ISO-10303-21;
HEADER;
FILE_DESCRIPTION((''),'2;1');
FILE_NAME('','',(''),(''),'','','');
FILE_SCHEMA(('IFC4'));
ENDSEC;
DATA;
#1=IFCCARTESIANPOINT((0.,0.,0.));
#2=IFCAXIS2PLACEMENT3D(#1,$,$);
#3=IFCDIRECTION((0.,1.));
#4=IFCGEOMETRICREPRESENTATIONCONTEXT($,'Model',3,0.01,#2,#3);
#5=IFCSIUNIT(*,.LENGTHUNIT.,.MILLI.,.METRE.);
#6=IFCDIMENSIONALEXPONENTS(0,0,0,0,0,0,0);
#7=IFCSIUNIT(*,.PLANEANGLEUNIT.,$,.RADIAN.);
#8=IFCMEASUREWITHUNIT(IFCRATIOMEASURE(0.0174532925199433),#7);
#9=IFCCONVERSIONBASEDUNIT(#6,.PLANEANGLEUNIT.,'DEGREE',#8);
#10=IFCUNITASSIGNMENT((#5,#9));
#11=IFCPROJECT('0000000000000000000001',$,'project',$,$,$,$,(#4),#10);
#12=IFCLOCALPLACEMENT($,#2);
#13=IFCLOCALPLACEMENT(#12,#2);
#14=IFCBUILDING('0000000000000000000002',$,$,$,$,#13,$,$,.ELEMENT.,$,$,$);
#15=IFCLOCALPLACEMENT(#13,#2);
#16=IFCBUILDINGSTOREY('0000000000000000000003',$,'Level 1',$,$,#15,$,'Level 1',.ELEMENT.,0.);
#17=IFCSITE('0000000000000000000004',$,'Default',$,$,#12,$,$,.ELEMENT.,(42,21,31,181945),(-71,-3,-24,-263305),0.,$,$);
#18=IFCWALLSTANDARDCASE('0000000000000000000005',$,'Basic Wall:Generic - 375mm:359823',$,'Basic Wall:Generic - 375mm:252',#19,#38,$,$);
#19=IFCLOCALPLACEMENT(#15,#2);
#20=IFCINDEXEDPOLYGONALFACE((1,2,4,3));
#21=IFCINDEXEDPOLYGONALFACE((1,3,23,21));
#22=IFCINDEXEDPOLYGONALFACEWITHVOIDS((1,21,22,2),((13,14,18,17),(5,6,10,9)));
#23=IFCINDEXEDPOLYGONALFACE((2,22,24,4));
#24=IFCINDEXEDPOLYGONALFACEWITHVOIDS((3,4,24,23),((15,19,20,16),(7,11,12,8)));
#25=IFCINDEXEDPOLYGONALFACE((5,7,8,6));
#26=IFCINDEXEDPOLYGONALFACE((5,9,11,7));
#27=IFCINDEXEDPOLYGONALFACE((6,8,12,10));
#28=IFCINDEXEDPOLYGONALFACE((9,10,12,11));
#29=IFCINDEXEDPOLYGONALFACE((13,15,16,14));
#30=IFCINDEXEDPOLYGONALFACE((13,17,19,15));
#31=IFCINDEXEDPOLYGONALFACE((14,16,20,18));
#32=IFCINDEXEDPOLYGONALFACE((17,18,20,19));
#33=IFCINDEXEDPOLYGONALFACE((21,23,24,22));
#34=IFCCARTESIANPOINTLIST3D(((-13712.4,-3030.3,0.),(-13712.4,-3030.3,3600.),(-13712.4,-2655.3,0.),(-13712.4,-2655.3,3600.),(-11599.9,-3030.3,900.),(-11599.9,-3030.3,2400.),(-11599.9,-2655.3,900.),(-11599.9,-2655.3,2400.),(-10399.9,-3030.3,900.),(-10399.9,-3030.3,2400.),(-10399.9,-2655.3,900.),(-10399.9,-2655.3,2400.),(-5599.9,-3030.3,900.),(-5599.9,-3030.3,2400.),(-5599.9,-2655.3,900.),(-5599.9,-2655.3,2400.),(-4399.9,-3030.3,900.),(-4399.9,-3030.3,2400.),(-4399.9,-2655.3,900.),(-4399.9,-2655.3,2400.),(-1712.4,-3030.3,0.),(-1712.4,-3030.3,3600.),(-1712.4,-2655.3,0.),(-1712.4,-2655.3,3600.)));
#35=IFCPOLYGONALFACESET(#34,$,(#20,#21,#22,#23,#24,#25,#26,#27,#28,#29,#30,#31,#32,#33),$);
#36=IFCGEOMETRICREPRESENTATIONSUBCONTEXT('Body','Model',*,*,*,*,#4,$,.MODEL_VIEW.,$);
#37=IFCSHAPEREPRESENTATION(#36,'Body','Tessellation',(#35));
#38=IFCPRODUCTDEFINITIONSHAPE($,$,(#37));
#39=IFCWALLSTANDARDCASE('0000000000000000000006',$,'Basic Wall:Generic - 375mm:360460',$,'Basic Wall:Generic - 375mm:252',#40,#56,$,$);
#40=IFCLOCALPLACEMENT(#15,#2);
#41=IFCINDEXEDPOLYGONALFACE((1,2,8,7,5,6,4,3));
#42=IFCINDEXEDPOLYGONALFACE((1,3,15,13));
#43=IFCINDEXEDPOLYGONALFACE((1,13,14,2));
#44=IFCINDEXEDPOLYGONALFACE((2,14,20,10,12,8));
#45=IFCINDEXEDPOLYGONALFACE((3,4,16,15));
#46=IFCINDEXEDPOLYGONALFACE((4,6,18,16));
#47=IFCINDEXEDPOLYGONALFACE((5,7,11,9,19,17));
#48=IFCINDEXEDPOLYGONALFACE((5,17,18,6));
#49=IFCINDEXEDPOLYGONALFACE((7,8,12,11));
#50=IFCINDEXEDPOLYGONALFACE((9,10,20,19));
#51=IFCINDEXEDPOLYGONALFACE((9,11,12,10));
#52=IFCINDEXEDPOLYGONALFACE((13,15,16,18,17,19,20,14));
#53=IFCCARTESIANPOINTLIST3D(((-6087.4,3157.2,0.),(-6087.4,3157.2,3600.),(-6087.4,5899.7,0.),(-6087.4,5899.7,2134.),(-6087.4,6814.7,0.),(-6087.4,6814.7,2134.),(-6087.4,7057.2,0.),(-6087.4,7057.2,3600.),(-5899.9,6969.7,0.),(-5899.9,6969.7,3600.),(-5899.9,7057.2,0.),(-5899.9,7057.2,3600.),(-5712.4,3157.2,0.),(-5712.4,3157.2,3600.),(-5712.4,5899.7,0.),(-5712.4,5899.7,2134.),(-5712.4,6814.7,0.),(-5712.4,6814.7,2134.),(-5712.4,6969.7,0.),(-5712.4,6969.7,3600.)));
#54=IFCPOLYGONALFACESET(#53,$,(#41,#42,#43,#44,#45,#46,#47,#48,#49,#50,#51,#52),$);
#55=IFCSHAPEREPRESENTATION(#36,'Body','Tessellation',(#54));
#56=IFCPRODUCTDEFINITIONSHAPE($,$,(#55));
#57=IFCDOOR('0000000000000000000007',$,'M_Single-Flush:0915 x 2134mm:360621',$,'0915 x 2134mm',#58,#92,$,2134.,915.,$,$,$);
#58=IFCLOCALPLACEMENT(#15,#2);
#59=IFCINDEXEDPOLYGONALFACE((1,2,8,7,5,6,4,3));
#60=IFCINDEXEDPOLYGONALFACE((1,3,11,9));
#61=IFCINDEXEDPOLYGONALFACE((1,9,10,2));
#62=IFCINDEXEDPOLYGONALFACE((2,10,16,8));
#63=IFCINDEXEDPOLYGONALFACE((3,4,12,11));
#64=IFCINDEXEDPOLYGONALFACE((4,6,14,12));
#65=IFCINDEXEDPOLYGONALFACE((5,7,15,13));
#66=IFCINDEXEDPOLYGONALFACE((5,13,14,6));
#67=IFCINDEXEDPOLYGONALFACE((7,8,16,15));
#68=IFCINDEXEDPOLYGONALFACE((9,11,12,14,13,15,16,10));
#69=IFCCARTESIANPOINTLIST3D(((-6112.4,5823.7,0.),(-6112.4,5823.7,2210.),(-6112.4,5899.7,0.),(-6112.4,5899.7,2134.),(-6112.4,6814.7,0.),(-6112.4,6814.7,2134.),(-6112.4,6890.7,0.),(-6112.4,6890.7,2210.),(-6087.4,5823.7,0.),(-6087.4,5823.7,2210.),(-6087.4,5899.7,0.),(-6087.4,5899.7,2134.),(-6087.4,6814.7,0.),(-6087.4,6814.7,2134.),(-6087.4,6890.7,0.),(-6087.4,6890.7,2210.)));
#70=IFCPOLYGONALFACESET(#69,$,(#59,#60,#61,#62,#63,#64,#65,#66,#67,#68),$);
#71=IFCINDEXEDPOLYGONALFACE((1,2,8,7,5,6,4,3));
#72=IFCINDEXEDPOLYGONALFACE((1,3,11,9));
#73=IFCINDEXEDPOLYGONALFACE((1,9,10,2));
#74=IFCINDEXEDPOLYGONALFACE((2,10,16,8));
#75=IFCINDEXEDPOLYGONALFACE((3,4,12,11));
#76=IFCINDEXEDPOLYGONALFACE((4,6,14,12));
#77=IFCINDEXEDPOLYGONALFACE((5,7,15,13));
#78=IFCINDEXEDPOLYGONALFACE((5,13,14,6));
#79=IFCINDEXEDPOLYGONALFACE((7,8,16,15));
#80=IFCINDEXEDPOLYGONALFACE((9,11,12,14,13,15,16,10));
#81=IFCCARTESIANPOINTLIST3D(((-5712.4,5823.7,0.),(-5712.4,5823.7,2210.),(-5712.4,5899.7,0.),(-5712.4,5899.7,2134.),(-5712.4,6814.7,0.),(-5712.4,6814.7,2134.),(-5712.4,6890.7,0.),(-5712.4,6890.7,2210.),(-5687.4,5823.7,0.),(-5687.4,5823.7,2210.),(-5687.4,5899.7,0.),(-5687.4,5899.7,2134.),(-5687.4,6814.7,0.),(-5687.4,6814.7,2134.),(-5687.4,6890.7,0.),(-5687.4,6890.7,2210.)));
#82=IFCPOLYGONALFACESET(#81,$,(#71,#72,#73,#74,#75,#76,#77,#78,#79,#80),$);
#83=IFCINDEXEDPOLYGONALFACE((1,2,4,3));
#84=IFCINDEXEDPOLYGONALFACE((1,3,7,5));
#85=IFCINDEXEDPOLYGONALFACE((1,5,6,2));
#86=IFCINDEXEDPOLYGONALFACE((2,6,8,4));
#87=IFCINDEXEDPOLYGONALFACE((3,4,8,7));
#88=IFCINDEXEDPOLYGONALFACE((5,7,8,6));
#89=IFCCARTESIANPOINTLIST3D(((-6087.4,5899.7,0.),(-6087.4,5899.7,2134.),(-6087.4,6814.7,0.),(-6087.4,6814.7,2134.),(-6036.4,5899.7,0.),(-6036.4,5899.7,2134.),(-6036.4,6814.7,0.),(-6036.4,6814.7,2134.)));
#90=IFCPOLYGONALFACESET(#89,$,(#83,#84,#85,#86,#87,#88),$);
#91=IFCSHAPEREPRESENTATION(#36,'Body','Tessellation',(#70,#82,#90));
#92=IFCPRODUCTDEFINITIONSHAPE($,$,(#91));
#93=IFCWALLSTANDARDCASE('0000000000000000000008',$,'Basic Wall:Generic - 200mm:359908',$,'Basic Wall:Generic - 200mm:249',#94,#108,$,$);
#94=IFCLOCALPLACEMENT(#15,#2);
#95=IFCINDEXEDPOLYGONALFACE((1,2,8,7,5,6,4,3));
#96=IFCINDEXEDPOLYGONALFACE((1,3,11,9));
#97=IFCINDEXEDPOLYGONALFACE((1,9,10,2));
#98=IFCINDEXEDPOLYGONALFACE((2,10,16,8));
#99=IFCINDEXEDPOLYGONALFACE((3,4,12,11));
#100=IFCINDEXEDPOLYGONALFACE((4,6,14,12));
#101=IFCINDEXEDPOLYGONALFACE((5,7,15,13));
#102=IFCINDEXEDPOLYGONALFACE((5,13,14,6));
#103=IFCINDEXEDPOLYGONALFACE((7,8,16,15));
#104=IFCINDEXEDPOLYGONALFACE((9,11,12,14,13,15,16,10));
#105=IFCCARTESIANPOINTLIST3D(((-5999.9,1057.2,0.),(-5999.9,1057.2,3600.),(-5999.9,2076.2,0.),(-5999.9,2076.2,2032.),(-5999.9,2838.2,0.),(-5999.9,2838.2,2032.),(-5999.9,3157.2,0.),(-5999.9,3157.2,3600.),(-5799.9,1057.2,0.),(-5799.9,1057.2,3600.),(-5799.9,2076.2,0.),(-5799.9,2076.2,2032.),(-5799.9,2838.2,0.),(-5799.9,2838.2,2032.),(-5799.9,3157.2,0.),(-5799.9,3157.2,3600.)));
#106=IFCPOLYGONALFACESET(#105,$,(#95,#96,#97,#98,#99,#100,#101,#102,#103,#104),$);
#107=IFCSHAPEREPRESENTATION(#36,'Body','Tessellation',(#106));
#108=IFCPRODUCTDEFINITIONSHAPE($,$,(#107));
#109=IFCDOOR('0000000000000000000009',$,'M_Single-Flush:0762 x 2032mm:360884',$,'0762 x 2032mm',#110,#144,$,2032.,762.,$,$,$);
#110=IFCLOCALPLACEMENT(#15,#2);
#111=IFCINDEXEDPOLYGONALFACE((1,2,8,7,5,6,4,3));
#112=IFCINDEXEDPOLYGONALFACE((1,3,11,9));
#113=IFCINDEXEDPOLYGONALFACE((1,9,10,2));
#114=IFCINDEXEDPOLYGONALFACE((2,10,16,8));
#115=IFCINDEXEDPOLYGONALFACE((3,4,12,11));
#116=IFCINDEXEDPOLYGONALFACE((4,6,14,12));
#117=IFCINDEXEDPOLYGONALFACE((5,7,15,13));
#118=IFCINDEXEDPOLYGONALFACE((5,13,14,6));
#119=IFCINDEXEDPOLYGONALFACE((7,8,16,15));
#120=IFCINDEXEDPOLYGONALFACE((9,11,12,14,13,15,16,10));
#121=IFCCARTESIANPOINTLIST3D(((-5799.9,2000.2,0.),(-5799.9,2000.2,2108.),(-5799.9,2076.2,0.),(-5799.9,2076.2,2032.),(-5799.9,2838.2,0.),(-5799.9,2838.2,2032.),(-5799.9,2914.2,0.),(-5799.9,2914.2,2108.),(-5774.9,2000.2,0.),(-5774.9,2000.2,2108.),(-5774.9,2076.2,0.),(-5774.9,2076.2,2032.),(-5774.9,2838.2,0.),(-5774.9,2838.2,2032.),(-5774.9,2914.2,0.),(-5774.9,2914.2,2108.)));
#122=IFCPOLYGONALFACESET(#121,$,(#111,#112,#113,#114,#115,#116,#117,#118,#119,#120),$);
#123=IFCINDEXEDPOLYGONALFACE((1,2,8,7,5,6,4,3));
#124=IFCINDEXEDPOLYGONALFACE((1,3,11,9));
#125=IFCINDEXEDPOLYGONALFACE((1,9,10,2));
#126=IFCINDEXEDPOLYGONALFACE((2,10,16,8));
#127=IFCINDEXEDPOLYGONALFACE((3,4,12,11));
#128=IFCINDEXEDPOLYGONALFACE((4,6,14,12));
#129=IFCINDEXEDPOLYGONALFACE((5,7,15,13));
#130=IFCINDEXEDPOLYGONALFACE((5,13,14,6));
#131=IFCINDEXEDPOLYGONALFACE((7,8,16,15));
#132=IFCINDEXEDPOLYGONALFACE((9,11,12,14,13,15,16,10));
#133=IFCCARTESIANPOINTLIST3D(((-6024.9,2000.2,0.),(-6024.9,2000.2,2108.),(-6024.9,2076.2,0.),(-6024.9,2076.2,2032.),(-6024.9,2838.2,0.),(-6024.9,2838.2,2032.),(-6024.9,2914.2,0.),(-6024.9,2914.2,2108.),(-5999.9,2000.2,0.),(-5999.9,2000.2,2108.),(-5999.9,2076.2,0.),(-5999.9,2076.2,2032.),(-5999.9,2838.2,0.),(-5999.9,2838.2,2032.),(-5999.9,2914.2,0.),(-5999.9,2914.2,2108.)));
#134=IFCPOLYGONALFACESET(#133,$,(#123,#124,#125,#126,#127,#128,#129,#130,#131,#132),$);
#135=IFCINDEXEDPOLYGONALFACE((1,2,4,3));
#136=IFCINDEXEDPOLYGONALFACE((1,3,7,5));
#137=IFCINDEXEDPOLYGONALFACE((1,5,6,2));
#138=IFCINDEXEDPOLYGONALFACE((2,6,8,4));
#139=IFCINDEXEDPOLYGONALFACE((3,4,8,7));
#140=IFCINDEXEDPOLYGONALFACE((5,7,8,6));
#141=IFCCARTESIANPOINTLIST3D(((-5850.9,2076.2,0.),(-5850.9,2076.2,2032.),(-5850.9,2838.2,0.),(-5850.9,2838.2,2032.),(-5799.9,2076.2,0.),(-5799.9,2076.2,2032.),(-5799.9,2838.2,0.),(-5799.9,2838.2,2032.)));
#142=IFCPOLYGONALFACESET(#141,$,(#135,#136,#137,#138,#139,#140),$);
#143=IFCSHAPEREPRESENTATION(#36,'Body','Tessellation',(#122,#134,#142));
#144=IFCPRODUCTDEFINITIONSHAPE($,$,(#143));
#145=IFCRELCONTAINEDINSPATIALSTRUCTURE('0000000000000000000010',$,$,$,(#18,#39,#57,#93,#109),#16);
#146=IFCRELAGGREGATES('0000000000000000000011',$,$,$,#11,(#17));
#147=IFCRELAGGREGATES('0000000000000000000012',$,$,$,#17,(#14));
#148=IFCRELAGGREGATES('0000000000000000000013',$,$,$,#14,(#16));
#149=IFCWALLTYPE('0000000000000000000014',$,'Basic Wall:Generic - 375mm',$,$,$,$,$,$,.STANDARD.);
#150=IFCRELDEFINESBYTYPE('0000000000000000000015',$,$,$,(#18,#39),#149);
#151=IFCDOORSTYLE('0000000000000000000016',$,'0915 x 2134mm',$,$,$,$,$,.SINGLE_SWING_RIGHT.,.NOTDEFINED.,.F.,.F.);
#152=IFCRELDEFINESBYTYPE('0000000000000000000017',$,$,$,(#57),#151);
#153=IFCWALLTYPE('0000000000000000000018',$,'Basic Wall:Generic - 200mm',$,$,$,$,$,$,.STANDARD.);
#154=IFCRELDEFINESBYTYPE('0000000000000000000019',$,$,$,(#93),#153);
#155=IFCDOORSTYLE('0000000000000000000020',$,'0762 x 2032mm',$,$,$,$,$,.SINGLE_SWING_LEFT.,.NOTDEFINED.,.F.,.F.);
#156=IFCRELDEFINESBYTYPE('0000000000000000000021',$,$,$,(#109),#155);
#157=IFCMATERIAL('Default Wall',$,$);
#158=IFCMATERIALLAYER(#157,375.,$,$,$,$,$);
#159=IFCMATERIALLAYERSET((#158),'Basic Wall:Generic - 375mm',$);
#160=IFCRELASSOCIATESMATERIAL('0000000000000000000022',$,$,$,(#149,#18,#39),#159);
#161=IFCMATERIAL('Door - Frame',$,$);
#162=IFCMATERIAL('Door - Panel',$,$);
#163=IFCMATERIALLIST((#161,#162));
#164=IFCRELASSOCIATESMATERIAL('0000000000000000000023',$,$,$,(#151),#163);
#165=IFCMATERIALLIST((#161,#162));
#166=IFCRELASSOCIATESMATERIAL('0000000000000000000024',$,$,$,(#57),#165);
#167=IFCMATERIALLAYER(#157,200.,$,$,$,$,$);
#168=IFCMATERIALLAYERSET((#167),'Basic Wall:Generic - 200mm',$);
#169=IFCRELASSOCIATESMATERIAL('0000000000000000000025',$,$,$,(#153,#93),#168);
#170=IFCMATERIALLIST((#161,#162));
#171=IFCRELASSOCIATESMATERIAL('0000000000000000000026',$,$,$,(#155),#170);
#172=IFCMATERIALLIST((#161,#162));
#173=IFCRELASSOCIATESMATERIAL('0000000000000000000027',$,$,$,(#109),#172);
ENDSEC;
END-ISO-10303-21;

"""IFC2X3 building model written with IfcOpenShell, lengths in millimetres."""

from ifc_helpers import new_model, entity, si_unit, converted_unit, direction, frame, frame_2d, origin, place, context, subcontext, project, spatial, polyline, rectangle, outline, extrude, clip, bounded_halfspace, source, transform, mapped, material, material_list, layer, layer_set, layer_usage, type_object, type_shapes, element, fill, save


model = new_model("IFC2X3")

# Units and contexts
model_context = context("Model", 3, precision=0.01, world=origin(), true_north=direction((0.0, 1.0)))
body_context = subcontext(model_context, "Body", "Model", "MODEL_VIEW")
ifc_project = project(units=[si_unit("LENGTHUNIT", "METRE", prefix="MILLI"), converted_unit("PLANEANGLEUNIT", "DEGREE", entity("IfcRatioMeasure", 0.0174532925199433), si_unit("PLANEANGLEUNIT", "RADIAN"), dimensions=[0, 0, 0, 0, 0, 0, 0])], contexts=[model_context])

# Site, building, storey
site_placement = place(None, origin())
site = spatial("IfcSite", under=ifc_project, at=site_placement, Name="Default", CompositionType="ELEMENT", RefLatitude=(42, 21, 31, 181945), RefLongitude=(-71, -3, -24, -263305), RefElevation=0.0)
building_placement = place(site_placement, origin())
building = spatial("IfcBuilding", under=site, at=building_placement, CompositionType="ELEMENT")
storey_placement = place(building_placement, origin())
storey = spatial("IfcBuildingStorey", under=building, at=storey_placement, Name="Level 1", LongName="Level 1", CompositionType="ELEMENT", Elevation=0.0)

# Wall, openings
ifc_material_1 = material(Name="Default Wall")
ifc_layer_1 = layer(ifc_material_1, 375.0)
ifc_layer_set_1 = layer_set([ifc_layer_1], Name="Basic Wall:Generic - 375mm")
ifc_layer_usage_1 = layer_usage(ifc_layer_set_1, "AXIS2", "NEGATIVE", 187.5)
wall_type_1 = type_object("IfcWallType", Name="Basic Wall:Generic - 375mm", PredefinedType="STANDARD", material=ifc_layer_set_1)
wall_1_placement = place(storey_placement, frame((-13712.4, -2842.8, 0.0)))
wall_1 = element("IfcWallStandardCase", 1, at=wall_1_placement, inside=storey, type_object=wall_type_1, material=ifc_layer_usage_1, Name="Basic Wall:Generic - 375mm:359823", ObjectType="Basic Wall:Generic - 375mm:252", context=body_context, shape_type="Clipping", body=[
    clip(extrude(rectangle(XDim=12000.0, YDim=375.0, at=frame_2d((6000.0, 0.0), x_axis=(-1.0, 0.0))), origin(), (0.0, 0.0, 1.0), 3600.0), bounded_halfspace(frame((0.0, -187.5, 3600.0), z_axis=(0.0, 0.0, -1.0), x_axis=(1.0, 0.0, 0.0)), True, frame((0.0, -187.5, 3600.0)), polyline([(0.0, 0.0), (12000.0, 0.0), (12000.0, 375.0), (11625.0, 375.0), (5712.5, 375.0), (5512.5, 375.0), (0.0, 375.0), (0.0, 0.0)]))),
])
opening_1_placement = place(wall_1_placement, frame((2112.5, -187.5, 900.0)))
element("IfcOpeningElement", 2, at=opening_1_placement, cuts=wall_1, ObjectType="Opening", context=body_context, shape_type="SweptSolid", body=[
    extrude(rectangle(XDim=1500.0, YDim=1200.0, at=frame_2d((750.0, 600.0), x_axis=(-1.0, 0.0))), frame((0.0, 0.0, 0.0), z_axis=(0.0, 1.0, 0.0), x_axis=(0.0, 0.0, 1.0)), (0.0, 0.0, 1.0), 375.0),
])
opening_2_placement = place(wall_1_placement, frame((8112.5, -187.5, 900.0)))
element("IfcOpeningElement", 3, at=opening_2_placement, cuts=wall_1, ObjectType="Opening", context=body_context, shape_type="SweptSolid", body=[
    extrude(rectangle(XDim=1500.0, YDim=1200.0, at=frame_2d((750.0, 600.0), x_axis=(-1.0, 0.0))), frame((0.0, 0.0, 0.0), z_axis=(0.0, 1.0, 0.0), x_axis=(0.0, 0.0, 1.0)), (0.0, 0.0, 1.0), 375.0),
])

# Walls, openings, doors
ifc_layer_usage_2 = layer_usage(ifc_layer_set_1, "AXIS2", "NEGATIVE", 187.5)
wall_2_placement = place(storey_placement, frame((-5899.9, 3157.2, 0.0), z_axis=(0.0, 0.0, 1.0), x_axis=(0.0, 1.0, 0.0)))
wall_2 = element("IfcWallStandardCase", 4, at=wall_2_placement, inside=storey, type_object=wall_type_1, material=ifc_layer_usage_2, Name="Basic Wall:Generic - 375mm:360460", ObjectType="Basic Wall:Generic - 375mm:252", context=body_context, shape_type="Clipping", body=[
    clip(extrude(outline(polyline([(0.0, -187.5), (187.5, -187.5), (3812.5, -187.5), (3812.5, 0.0), (3900.0, 0.0), (3900.0, 187.5), (0.0, 187.5), (0.0, 100.0), (0.0, -100.0), (0.0, -187.5)])), origin(), (0.0, 0.0, 1.0), 3600.0), bounded_halfspace(frame((0.0, -187.5, 3600.0), z_axis=(0.0, 0.0, -1.0), x_axis=(0.0, -1.0, 0.0)), True, frame((0.0, -187.5, 3600.0)), polyline([(0.0, 0.0), (187.5, 0.0), (3812.5, 0.0), (3812.5, 187.5), (3900.0, 187.5), (3900.0, 375.0), (0.0, 375.0), (0.0, 287.5), (0.0, 87.5), (0.0, 0.0)]))),
])
opening_3_placement = place(wall_2_placement, frame((2742.5, -187.5, 0.0)))
opening_3 = element("IfcOpeningElement", 5, at=opening_3_placement, cuts=wall_2, ObjectType="Opening", context=body_context, shape_type="SweptSolid", body=[
    extrude(rectangle(XDim=915.0, YDim=2134.0, at=frame_2d((1067.0, 457.5), x_axis=(0.0, 1.0))), frame((0.0, 0.0, 0.0), z_axis=(0.0, 1.0, 0.0), x_axis=(0.0, 0.0, 1.0)), (0.0, 0.0, 1.0), 375.0),
])
ifc_material_2 = material(Name="Door - Frame")
ifc_material_3 = material(Name="Door - Panel")
ifc_material_list_1 = material_list([ifc_material_2, ifc_material_3])
ifc_material_list_2 = material_list([ifc_material_2, ifc_material_3])
door_style_1 = type_object("IfcDoorStyle", Name="0915 x 2134mm", ConstructionType="NOTDEFINED", OperationType="SINGLE_SWING_RIGHT", ParameterTakesPrecedence=False, Sizeable=False, material=ifc_material_list_2)
shared_shape_1 = source(origin(), body_context, "Body", "SweptSolid", [
    extrude(outline(polyline([(-533.5, -1124.0), (533.5, -1124.0), (533.5, 1086.0), (457.5, 1086.0), (457.5, -1048.0), (-457.5, -1048.0), (-457.5, 1086.0), (-533.5, 1086.0), (-533.5, -1124.0)])), frame((457.5, 375.0, 1086.0), z_axis=(0.0, 1.0, 0.0), x_axis=(1.0, 0.0, 0.0)), (0.0, 0.0, 1.0), 25.0),
    extrude(outline(polyline([(-1124.0, -533.5), (1086.0, -533.5), (1086.0, -457.5), (-1048.0, -457.5), (-1048.0, 457.5), (1086.0, 457.5), (1086.0, 533.5), (-1124.0, 533.5), (-1124.0, -533.5)])), frame((457.5, -25.0, 1086.0), z_axis=(0.0, 1.0, 0.0), x_axis=(0.0, 0.0, -1.0)), (0.0, 0.0, 1.0), 25.0),
    extrude(rectangle(XDim=51.0, YDim=915.0, at=frame_2d((0.0, 0.0), x_axis=(1.0, 0.0))), frame((457.5, 349.5, 0.0), z_axis=(0.0, 0.0, 1.0), x_axis=(0.0, 1.0, 0.0)), (0.0, 0.0, 1.0), 2134.0),
])
type_shapes(door_style_1, [shared_shape_1])
door_1_placement = place(opening_3_placement, origin())
door_1 = element("IfcDoor", 6, at=door_1_placement, inside=storey, type_object=door_style_1, material=ifc_material_list_1, Name="M_Single-Flush:0915 x 2134mm:360621", ObjectType="0915 x 2134mm", OverallHeight=2134.0, OverallWidth=915.0, context=body_context, shape_type="MappedRepresentation", body=[
    mapped(shared_shape_1, transform((0.0, 0.0, 0.0), scale=1.0)),
])
fill(opening_3, door_1)
ifc_layer_2 = layer(ifc_material_1, 200.0)
ifc_layer_set_2 = layer_set([ifc_layer_2], Name="Basic Wall:Generic - 200mm")
ifc_layer_usage_3 = layer_usage(ifc_layer_set_2, "AXIS2", "NEGATIVE", 100.0)
wall_type_2 = type_object("IfcWallType", Name="Basic Wall:Generic - 200mm", PredefinedType="STANDARD", material=ifc_layer_set_2)
wall_3_placement = place(storey_placement, frame((-5899.9, 1057.2, 0.0), z_axis=(0.0, 0.0, 1.0), x_axis=(0.0, 1.0, 0.0)))
wall_3 = element("IfcWallStandardCase", 7, at=wall_3_placement, inside=storey, type_object=wall_type_2, material=ifc_layer_usage_3, Name="Basic Wall:Generic - 200mm:359908", ObjectType="Basic Wall:Generic - 200mm:249", context=body_context, shape_type="Clipping", body=[
    clip(extrude(rectangle(XDim=2100.0, YDim=200.0, at=frame_2d((1050.0, 0.0), x_axis=(-1.0, 0.0))), origin(), (0.0, 0.0, 1.0), 3600.0), bounded_halfspace(frame((0.0, -100.0, 3600.0), z_axis=(0.0, 0.0, -1.0), x_axis=(0.0, -1.0, 0.0)), True, frame((0.0, -100.0, 3600.0)), polyline([(0.0, 0.0), (1912.5, 0.0), (2100.0, 0.0), (2100.0, 200.0), (0.0, 200.0), (0.0, 0.0)]))),
])
opening_4_placement = place(wall_3_placement, frame((1781.0, 100.0, 0.0)))
opening_4 = element("IfcOpeningElement", 8, at=opening_4_placement, cuts=wall_3, ObjectType="Opening", context=body_context, shape_type="SweptSolid", body=[
    extrude(rectangle(XDim=762.0, YDim=2032.0, at=frame_2d((1016.0, 381.0), x_axis=(0.0, -1.0))), frame((0.0, 0.0, 0.0), z_axis=(0.0, -1.0, 0.0), x_axis=(0.0, 0.0, 1.0)), (0.0, 0.0, 1.0), 200.0),
])
ifc_material_list_3 = material_list([ifc_material_2, ifc_material_3])
ifc_material_list_4 = material_list([ifc_material_2, ifc_material_3])
door_style_2 = type_object("IfcDoorStyle", Name="0762 x 2032mm", ConstructionType="NOTDEFINED", OperationType="SINGLE_SWING_LEFT", ParameterTakesPrecedence=False, Sizeable=False, material=ifc_material_list_4)
shared_shape_2 = source(origin(), body_context, "Body", "SweptSolid", [
    extrude(outline(polyline([(-457.0, -1073.0), (457.0, -1073.0), (457.0, 1035.0), (381.0, 1035.0), (381.0, -997.0), (-381.0, -997.0), (-381.0, 1035.0), (-457.0, 1035.0), (-457.0, -1073.0)])), frame((381.0, 225.0, 1035.0), z_axis=(0.0, -1.0, 0.0), x_axis=(-1.0, 0.0, 0.0)), (0.0, 0.0, 1.0), 25.0),
    extrude(outline(polyline([(-1073.0, -457.0), (1035.0, -457.0), (1035.0, -381.0), (-997.0, -381.0), (-997.0, 381.0), (1035.0, 381.0), (1035.0, 457.0), (-1073.0, 457.0), (-1073.0, -457.0)])), frame((381.0, 0.0, 1035.0), z_axis=(0.0, -1.0, 0.0), x_axis=(0.0, 0.0, -1.0)), (0.0, 0.0, 1.0), 25.0),
    extrude(rectangle(XDim=762.0, YDim=51.0, at=frame_2d((0.0, 0.0), x_axis=(1.0, 0.0))), frame((381.0, 174.5, 0.0)), (0.0, 0.0, 1.0), 2032.0),
])
type_shapes(door_style_2, [shared_shape_2])
door_2_placement = place(opening_4_placement, frame((0.0, 0.0, 0.0), z_axis=(0.0, 0.0, 1.0), x_axis=(-1.0, 0.0, 0.0)))
door_2 = element("IfcDoor", 9, at=door_2_placement, inside=storey, type_object=door_style_2, material=ifc_material_list_3, Name="M_Single-Flush:0762 x 2032mm:360884", ObjectType="0762 x 2032mm", OverallHeight=2032.0, OverallWidth=762.0, context=body_context, shape_type="MappedRepresentation", body=[
    mapped(shared_shape_2, transform((0.0, 0.0, 0.0), scale=1.0)),
])
fill(opening_4, door_2)

save(model, "model.ifc")
